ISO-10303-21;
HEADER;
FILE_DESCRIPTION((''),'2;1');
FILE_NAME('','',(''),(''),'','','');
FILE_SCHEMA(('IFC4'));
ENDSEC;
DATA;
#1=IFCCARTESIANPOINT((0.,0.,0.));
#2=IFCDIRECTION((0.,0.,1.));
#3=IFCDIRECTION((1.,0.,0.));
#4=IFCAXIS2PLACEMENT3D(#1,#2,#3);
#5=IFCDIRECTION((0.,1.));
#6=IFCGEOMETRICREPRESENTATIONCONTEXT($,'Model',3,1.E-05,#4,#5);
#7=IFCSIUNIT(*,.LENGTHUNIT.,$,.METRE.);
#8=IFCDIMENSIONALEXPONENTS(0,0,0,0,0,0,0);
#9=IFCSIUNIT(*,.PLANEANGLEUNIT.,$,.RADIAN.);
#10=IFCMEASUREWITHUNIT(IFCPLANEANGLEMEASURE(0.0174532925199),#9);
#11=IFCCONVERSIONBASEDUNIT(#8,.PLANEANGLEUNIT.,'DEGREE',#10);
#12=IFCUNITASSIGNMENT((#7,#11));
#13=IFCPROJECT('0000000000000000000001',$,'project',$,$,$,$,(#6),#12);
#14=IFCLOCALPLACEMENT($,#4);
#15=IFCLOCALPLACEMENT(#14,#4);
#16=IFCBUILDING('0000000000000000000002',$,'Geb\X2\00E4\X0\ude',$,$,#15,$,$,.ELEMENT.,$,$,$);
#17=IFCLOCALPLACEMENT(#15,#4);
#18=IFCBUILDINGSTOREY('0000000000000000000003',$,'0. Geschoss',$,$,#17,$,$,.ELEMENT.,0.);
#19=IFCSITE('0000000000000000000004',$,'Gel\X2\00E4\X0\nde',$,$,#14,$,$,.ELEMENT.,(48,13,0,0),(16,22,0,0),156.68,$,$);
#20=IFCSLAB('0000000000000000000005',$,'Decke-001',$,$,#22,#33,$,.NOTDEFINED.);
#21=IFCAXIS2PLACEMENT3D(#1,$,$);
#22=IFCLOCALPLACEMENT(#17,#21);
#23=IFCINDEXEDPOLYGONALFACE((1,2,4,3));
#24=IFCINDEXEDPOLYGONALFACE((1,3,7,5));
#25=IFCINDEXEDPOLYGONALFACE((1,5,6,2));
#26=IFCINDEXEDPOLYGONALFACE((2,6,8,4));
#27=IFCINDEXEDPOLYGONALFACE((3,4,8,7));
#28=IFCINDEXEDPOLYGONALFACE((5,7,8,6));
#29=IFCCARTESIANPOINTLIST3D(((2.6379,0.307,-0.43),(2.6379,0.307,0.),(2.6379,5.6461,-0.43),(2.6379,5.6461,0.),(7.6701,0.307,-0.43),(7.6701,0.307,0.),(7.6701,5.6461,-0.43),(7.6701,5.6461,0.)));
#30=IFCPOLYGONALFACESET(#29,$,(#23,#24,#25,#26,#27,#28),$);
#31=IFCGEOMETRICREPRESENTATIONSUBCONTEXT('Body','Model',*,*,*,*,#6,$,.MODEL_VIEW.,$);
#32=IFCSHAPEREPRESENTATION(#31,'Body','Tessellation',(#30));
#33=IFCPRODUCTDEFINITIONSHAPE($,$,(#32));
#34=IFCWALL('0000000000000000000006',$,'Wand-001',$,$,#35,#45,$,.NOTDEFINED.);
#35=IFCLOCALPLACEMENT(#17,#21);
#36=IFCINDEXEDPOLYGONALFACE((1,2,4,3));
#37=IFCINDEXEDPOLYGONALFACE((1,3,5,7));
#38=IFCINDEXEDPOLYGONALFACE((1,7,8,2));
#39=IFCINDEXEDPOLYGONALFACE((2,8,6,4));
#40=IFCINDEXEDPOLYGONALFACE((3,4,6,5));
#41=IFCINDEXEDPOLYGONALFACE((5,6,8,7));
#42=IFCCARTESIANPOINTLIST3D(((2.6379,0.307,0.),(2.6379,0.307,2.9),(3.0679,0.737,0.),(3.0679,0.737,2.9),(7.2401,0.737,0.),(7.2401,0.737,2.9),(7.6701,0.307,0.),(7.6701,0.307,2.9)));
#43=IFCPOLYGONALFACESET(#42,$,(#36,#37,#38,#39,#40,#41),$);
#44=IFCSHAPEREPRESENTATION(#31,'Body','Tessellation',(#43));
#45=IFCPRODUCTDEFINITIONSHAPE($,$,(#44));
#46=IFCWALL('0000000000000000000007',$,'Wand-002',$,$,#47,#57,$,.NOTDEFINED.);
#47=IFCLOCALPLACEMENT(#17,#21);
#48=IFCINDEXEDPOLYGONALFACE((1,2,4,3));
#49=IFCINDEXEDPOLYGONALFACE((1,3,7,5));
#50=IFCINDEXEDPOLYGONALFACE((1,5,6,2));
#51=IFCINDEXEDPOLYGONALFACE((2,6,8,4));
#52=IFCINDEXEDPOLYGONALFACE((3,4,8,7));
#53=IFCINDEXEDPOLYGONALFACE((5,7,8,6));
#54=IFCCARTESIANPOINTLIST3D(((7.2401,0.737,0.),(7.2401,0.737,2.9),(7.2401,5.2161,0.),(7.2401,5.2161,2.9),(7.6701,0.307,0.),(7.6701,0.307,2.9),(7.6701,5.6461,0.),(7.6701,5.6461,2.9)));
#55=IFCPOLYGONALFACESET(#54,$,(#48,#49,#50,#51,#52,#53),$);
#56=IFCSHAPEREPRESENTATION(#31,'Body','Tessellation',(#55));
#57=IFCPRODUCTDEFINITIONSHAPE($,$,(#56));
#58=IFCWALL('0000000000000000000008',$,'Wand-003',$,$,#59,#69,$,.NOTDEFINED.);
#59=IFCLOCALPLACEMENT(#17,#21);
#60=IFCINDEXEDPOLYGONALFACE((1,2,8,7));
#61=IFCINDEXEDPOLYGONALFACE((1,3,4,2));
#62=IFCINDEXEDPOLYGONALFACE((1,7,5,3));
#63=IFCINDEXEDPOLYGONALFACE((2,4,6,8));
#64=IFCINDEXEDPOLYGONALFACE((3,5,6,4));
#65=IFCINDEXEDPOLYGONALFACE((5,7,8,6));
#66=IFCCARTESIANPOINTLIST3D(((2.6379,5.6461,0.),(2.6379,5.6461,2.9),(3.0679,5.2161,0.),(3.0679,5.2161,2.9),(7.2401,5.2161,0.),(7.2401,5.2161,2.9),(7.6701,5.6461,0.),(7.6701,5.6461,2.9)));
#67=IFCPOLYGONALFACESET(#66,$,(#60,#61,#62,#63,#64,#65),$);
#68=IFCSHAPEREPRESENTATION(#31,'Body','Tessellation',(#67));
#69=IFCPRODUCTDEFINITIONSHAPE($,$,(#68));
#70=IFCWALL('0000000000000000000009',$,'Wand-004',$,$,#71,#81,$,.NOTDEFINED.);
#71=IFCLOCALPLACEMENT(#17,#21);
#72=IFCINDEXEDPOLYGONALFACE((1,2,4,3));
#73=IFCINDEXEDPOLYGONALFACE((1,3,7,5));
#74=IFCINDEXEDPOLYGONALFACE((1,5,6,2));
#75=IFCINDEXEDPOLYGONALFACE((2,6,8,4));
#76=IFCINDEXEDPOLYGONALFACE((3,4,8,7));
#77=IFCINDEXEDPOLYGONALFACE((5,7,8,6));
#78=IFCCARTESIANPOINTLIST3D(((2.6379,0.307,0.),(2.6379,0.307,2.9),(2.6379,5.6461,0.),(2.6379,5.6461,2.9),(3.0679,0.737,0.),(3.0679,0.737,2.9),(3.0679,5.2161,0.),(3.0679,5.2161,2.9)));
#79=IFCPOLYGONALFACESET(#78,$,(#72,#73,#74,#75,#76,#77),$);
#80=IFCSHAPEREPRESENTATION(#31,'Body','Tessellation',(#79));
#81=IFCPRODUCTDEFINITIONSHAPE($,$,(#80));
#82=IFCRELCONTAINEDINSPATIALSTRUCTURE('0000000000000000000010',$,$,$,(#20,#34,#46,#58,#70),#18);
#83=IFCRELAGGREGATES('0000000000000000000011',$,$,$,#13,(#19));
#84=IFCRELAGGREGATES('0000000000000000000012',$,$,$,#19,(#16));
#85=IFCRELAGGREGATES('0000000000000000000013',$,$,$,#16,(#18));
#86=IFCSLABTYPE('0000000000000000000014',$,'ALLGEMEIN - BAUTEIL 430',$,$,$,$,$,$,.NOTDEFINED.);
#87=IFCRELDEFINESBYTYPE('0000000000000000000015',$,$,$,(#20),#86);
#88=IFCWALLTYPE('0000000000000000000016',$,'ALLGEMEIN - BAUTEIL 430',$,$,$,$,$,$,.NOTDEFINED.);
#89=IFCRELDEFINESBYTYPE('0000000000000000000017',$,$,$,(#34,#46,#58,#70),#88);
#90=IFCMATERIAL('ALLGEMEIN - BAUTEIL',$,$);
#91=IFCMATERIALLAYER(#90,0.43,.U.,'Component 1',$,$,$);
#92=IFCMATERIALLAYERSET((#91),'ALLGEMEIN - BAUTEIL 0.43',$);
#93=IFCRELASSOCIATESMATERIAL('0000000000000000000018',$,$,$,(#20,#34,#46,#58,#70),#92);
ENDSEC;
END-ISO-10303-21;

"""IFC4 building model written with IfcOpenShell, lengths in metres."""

from ifc_helpers import new_model, entity, si_unit, converted_unit, direction, frame, origin_with_axes, place, context, subcontext, project, spatial, line, indexed_curve, outline, extrude, material, layer, layer_set, layer_usage, type_object, element, save


model = new_model("IFC4")

# Units and contexts
model_context = context("Model", 3, precision=1e-05, world=origin_with_axes(), true_north=direction((0.0, 1.0)))
body_context = subcontext(model_context, "Body", "Model", "MODEL_VIEW")
ifc_project = project(units=[si_unit("LENGTHUNIT", "METRE"), converted_unit("PLANEANGLEUNIT", "DEGREE", entity("IfcPlaneAngleMeasure", 0.0174532925199), si_unit("PLANEANGLEUNIT", "RADIAN"), dimensions=[0, 0, 0, 0, 0, 0, 0])], contexts=[model_context])

# Site, building, storey
site_placement = place(None, origin_with_axes())
site = spatial("IfcSite", under=ifc_project, at=site_placement, Name="Gelände", CompositionType="ELEMENT", RefLatitude=(48, 13, 0, 0), RefLongitude=(16, 22, 0, 0), RefElevation=156.68)
building_placement = place(site_placement, origin_with_axes())
building = spatial("IfcBuilding", under=site, at=building_placement, Name="Gebäude", CompositionType="ELEMENT")
storey_placement = place(building_placement, origin_with_axes())
storey = spatial("IfcBuildingStorey", under=building, at=storey_placement, Name="0. Geschoss", CompositionType="ELEMENT", Elevation=0.0)

# Slab
ifc_material = material(Name="ALLGEMEIN - BAUTEIL")
ifc_layer = layer(ifc_material, 0.43, ventilated="UNKNOWN", Name="Component 1")
ifc_layer_set = layer_set([ifc_layer], Name="ALLGEMEIN - BAUTEIL 0.43")
ifc_layer_usage_1 = layer_usage(ifc_layer_set, "AXIS3", "NEGATIVE", 0.43)
slab_type = type_object("IfcSlabType", Name="ALLGEMEIN - BAUTEIL 430", PredefinedType="NOTDEFINED")
slab_placement = place(storey_placement, frame((2.6379, 0.307, 0.0), z_axis=(0.0, 0.0, 1.0), x_axis=(1.0, 0.0, 0.0)))
element("IfcSlab", 1, at=slab_placement, inside=storey, type_object=slab_type, material=ifc_layer_usage_1, Name="Decke-001", PredefinedType="NOTDEFINED", context=body_context, shape_type="SweptSolid", body=[
    extrude(outline(indexed_curve([(0.0, 0.0), (5.0323, 0.0), (5.0323, 5.3391), (0.0, 5.3391)], segments=[line(1, 2, 3, 4, 1)])), frame((0.0, 0.0, -0.43), z_axis=(0.0, 0.0, 1.0), x_axis=(1.0, 0.0, 0.0)), (0.0, 0.0, 1.0), 0.43),
])

# Walls
ifc_layer_usage_2 = layer_usage(ifc_layer_set, "AXIS2", "POSITIVE", 0.0)
wall_type = type_object("IfcWallType", Name="ALLGEMEIN - BAUTEIL 430", PredefinedType="NOTDEFINED")
wall_1_placement = place(storey_placement, frame((2.6379, 0.307, 0.0), z_axis=(0.0, 0.0, 1.0), x_axis=(1.0, 0.0, 0.0)))
element("IfcWall", 2, at=wall_1_placement, inside=storey, type_object=wall_type, material=ifc_layer_usage_2, Name="Wand-001", PredefinedType="NOTDEFINED", context=body_context, shape_type="SweptSolid", body=[
    extrude(outline(indexed_curve([(0.0, 0.0), (5.0323, 0.0), (4.6023, 0.43), (0.43, 0.43)], segments=[line(1, 2, 3, 4, 1)])), origin_with_axes(), (0.0, 0.0, 1.0), 2.9),
])
ifc_layer_usage_3 = layer_usage(ifc_layer_set, "AXIS2", "POSITIVE", 0.0)
wall_2_placement = place(storey_placement, frame((7.6701, 0.307, 0.0), z_axis=(0.0, 0.0, 1.0), x_axis=(0.0, 1.0, 0.0)))
element("IfcWall", 3, at=wall_2_placement, inside=storey, type_object=wall_type, material=ifc_layer_usage_3, Name="Wand-002", PredefinedType="NOTDEFINED", context=body_context, shape_type="SweptSolid", body=[
    extrude(outline(indexed_curve([(0.0, 0.0), (5.3391, 0.0), (4.9091, 0.43), (0.43, 0.43)], segments=[line(1, 2, 3, 4, 1)])), origin_with_axes(), (0.0, 0.0, 1.0), 2.9),
])
ifc_layer_usage_4 = layer_usage(ifc_layer_set, "AXIS2", "POSITIVE", 0.0)
wall_3_placement = place(storey_placement, frame((7.6701, 5.6461, 0.0), z_axis=(0.0, 0.0, 1.0), x_axis=(-1.0, 0.0, 0.0)))
element("IfcWall", 4, at=wall_3_placement, inside=storey, type_object=wall_type, material=ifc_layer_usage_4, Name="Wand-003", PredefinedType="NOTDEFINED", context=body_context, shape_type="SweptSolid", body=[
    extrude(outline(indexed_curve([(0.0, 0.0), (5.0323, 0.0), (4.6023, 0.43), (0.43, 0.43)], segments=[line(1, 2, 3, 4, 1)])), origin_with_axes(), (0.0, 0.0, 1.0), 2.9),
])
ifc_layer_usage_5 = layer_usage(ifc_layer_set, "AXIS2", "POSITIVE", 0.0)
wall_4_placement = place(storey_placement, frame((2.6379, 5.6461, 0.0), z_axis=(0.0, 0.0, 1.0), x_axis=(0.0, -1.0, 0.0)))
element("IfcWall", 5, at=wall_4_placement, inside=storey, type_object=wall_type, material=ifc_layer_usage_5, Name="Wand-004", PredefinedType="NOTDEFINED", context=body_context, shape_type="SweptSolid", body=[
    extrude(outline(indexed_curve([(0.0, 0.0), (5.3391, 0.0), (4.9091, 0.43), (0.43, 0.43)], segments=[line(1, 2, 3, 4, 1)])), origin_with_axes(), (0.0, 0.0, 1.0), 2.9),
])

save(model, "model.ifc")
